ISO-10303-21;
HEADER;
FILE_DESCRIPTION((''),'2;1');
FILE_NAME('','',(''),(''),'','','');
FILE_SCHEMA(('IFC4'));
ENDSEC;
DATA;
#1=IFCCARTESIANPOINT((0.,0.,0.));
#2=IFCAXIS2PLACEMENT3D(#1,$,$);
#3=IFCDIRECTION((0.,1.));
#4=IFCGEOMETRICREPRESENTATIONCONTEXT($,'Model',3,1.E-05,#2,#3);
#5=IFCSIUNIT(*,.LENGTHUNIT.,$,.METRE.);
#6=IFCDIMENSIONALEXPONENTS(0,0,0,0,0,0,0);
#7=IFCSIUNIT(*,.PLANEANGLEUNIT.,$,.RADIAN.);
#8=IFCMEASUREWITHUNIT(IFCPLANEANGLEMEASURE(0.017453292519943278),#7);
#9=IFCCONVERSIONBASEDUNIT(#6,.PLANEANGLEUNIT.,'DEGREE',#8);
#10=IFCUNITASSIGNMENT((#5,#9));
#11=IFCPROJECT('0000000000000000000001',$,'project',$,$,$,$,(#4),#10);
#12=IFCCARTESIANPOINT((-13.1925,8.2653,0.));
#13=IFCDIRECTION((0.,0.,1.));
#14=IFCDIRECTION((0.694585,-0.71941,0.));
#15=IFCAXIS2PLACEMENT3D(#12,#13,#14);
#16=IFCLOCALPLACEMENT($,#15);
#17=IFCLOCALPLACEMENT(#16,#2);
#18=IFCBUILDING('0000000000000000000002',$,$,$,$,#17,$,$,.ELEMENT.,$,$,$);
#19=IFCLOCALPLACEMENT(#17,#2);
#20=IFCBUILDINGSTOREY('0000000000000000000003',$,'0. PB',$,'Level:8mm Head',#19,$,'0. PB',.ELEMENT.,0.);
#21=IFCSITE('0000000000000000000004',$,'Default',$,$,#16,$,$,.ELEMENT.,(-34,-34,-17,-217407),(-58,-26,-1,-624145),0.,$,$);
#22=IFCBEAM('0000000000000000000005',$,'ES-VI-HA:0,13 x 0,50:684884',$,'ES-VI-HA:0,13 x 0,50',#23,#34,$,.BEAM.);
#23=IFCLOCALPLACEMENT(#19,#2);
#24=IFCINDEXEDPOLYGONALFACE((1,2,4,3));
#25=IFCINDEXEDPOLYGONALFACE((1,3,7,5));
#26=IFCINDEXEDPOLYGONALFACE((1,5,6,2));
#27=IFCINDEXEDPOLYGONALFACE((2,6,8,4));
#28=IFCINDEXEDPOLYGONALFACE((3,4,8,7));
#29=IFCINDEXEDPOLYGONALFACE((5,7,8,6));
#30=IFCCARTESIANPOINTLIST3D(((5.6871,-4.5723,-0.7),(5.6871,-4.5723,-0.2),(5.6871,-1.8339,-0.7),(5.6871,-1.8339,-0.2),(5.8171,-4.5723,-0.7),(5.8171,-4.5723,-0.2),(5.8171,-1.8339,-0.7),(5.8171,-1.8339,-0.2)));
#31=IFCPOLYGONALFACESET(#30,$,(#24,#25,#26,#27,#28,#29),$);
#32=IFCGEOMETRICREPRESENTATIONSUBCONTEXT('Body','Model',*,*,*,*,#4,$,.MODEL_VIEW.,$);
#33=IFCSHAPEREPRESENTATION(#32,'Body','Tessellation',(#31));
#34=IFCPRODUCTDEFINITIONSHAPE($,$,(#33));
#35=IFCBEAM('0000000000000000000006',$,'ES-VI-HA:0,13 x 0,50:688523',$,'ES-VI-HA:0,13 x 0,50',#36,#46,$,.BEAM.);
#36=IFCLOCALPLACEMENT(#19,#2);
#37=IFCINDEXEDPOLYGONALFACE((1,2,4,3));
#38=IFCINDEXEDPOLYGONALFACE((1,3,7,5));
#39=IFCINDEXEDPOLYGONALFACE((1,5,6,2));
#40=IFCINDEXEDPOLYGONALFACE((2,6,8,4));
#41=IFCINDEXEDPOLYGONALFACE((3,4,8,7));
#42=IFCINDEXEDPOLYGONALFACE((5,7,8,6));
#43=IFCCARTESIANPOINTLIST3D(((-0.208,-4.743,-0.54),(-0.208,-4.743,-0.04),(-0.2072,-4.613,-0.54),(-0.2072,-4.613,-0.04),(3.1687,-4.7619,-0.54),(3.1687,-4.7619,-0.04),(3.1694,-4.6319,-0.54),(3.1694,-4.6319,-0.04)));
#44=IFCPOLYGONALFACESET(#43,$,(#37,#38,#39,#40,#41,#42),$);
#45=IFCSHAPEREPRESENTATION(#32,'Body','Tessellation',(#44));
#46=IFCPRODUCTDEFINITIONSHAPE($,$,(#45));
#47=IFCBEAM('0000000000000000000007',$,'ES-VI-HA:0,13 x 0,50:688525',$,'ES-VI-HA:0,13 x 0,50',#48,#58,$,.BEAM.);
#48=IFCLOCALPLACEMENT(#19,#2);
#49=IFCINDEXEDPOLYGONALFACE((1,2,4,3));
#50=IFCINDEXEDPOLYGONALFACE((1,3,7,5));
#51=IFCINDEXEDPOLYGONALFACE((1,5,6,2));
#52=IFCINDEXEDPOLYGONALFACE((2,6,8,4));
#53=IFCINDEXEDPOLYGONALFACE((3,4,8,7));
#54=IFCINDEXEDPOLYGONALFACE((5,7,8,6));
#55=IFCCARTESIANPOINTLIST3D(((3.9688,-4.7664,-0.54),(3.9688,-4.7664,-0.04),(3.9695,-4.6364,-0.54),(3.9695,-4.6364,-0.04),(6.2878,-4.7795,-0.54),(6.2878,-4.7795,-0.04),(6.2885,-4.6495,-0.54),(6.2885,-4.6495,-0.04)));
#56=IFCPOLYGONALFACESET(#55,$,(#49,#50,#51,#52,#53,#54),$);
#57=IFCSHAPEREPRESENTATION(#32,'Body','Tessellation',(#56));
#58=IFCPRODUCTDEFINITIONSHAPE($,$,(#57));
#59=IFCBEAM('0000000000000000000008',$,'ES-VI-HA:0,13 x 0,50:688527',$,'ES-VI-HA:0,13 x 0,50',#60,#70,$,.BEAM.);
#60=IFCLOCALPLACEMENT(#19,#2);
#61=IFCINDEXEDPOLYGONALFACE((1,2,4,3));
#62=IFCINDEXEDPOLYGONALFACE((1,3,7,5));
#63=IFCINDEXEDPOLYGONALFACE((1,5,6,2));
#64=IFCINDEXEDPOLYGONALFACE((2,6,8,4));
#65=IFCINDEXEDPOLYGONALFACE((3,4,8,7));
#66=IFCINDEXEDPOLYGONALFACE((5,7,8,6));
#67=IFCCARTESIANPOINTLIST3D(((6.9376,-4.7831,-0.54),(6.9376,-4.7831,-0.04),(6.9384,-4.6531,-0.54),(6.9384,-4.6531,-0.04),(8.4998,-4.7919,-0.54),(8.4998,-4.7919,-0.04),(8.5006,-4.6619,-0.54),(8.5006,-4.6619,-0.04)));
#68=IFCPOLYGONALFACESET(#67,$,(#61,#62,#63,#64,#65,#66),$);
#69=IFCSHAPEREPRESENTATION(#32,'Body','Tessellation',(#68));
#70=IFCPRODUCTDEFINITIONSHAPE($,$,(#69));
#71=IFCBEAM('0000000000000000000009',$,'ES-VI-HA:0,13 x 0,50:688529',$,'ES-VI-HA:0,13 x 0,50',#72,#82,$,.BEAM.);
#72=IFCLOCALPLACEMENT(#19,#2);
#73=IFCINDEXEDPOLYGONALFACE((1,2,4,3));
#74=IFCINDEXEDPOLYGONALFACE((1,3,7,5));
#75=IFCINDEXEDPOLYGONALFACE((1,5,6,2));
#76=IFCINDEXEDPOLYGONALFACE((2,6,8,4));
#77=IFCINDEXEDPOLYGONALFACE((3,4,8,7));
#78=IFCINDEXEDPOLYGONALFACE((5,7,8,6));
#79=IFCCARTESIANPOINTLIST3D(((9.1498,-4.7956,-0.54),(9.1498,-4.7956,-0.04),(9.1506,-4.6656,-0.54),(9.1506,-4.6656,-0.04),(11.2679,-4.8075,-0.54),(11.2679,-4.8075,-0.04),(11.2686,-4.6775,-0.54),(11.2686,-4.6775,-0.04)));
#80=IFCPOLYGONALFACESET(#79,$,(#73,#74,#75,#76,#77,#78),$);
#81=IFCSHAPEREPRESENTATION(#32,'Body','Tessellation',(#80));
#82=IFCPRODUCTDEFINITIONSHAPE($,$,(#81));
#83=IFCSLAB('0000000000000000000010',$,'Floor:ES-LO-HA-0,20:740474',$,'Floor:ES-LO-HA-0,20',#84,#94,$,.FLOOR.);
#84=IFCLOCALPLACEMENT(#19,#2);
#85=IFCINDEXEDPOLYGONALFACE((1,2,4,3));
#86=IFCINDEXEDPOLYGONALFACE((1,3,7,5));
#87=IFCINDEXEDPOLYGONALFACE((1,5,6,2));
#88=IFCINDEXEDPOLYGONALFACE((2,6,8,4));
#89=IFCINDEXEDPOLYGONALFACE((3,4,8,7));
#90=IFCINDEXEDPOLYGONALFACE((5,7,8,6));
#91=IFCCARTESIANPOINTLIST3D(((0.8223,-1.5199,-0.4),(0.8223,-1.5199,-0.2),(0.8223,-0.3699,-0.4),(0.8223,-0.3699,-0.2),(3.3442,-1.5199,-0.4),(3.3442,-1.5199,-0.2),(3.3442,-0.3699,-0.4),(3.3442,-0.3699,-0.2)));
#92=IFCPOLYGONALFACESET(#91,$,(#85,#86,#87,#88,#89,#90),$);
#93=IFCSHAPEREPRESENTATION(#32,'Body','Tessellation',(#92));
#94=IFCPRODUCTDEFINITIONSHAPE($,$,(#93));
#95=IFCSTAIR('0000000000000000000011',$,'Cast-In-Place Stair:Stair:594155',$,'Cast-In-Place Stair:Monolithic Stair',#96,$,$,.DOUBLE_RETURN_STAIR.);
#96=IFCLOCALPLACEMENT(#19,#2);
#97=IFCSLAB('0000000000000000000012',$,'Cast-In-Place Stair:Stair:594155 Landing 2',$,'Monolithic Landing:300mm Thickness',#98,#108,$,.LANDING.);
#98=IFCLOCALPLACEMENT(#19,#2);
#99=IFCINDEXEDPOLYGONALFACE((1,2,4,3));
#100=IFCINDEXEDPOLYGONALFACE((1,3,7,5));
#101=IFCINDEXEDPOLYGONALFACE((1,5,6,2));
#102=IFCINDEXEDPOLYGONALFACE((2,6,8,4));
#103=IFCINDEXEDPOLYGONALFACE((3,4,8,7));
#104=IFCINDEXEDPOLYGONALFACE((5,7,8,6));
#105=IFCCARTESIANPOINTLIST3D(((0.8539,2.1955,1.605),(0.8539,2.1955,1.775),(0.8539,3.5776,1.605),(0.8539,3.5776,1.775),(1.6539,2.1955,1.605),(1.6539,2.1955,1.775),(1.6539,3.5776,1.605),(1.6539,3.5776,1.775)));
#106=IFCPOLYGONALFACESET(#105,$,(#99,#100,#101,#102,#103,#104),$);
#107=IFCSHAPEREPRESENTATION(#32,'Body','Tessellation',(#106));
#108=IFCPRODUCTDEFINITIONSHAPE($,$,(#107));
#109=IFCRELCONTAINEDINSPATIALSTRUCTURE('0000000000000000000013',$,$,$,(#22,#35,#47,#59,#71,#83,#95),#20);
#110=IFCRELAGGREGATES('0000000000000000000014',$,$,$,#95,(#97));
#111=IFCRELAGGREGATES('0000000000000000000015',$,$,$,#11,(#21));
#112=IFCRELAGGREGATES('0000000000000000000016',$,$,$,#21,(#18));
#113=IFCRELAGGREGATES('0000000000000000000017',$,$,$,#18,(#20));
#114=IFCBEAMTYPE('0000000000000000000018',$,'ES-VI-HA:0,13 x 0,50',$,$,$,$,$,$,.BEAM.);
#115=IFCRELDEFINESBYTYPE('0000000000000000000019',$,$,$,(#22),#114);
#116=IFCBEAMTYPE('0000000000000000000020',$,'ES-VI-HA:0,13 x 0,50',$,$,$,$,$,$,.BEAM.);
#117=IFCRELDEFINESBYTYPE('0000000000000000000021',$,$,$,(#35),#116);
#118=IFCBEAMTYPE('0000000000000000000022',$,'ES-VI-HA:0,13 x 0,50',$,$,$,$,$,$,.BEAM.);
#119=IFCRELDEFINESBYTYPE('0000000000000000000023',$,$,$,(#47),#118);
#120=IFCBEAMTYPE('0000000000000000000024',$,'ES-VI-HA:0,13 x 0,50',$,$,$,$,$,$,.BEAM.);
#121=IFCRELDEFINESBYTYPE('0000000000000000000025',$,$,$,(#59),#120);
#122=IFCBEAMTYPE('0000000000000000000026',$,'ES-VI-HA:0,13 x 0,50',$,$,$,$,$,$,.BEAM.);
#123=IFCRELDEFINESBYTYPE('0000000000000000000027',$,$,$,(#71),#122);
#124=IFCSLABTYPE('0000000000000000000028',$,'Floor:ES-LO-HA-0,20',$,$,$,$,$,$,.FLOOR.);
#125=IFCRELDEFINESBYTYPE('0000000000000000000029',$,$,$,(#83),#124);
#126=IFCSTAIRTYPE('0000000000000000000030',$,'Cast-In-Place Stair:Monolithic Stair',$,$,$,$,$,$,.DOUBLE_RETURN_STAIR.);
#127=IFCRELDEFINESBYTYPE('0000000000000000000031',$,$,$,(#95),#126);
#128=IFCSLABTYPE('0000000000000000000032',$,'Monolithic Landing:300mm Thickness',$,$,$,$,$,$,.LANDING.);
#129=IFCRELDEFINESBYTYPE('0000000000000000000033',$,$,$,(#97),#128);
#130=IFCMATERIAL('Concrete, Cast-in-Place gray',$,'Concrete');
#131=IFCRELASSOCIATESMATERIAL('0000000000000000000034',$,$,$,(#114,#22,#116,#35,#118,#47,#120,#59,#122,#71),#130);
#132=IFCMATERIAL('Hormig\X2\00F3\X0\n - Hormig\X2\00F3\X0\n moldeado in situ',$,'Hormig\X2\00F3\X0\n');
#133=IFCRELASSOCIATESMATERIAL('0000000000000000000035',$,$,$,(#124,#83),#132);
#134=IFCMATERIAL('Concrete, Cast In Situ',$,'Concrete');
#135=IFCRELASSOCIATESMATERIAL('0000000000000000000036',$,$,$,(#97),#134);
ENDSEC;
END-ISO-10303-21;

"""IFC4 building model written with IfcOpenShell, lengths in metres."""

from ifc_helpers import new_model, entity, si_unit, converted_unit, direction, frame, origin, place, context, subcontext, project, spatial, indexed_curve, outline, extrude, source, transform, mapped, material, type_object, type_shapes, element, aggregate, save


model = new_model("IFC4")

# Units and contexts
model_context = context("Model", 3, precision=1e-05, world=origin(), true_north=direction((0.0, 1.0)))
body_context = subcontext(model_context, "Body", "Model", "MODEL_VIEW")
ifc_project = project(units=[si_unit("LENGTHUNIT", "METRE"), converted_unit("PLANEANGLEUNIT", "DEGREE", entity("IfcPlaneAngleMeasure", 0.017453292519943278), si_unit("PLANEANGLEUNIT", "RADIAN"), dimensions=[0, 0, 0, 0, 0, 0, 0])], contexts=[model_context])

# Site, building, storey
site_placement = place(None, frame((-13.1925, 8.2653, 0.0), z_axis=(0.0, 0.0, 1.0), x_axis=(0.694585, -0.71941, 0.0)))
site = spatial("IfcSite", under=ifc_project, at=site_placement, Name="Default", CompositionType="ELEMENT", RefLatitude=(-34, -34, -17, -217407), RefLongitude=(-58, -26, -1, -624145), RefElevation=0.0)
building_placement = place(site_placement, origin())
building = spatial("IfcBuilding", under=site, at=building_placement, CompositionType="ELEMENT")
storey_placement = place(building_placement, origin())
storey = spatial("IfcBuildingStorey", under=building, at=storey_placement, Name="0. PB", ObjectType="Level:8mm Head", LongName="0. PB", CompositionType="ELEMENT", Elevation=0.0)

# Shared definitions
ifc_material_1 = material(Name="Concrete, Cast-in-Place gray", Category="Concrete")

# Beams
beam_type_1 = type_object("IfcBeamType", Name="ES-VI-HA:0,13 x 0,50", PredefinedType="BEAM", material=ifc_material_1)
shared_shape_1 = source(origin(), body_context, "Body", "SweptSolid", [
    extrude(outline(indexed_curve([(-0.065, -0.25), (0.065, -0.25), (0.065, 0.25), (-0.065, 0.25), (-0.065, -0.25)], self_intersect=False)), frame((5.7521, -1.8339, -0.45), z_axis=(0.0, -1.0, 0.0), x_axis=(-1.0, 0.0, 0.0)), (0.0, 0.0, 1.0), 2.7384),
])
type_shapes(beam_type_1, [shared_shape_1])
beam_1_placement = place(storey_placement, origin())
element("IfcBeam", 1, at=beam_1_placement, inside=storey, type_object=beam_type_1, material=ifc_material_1, Name="ES-VI-HA:0,13 x 0,50:684884", ObjectType="ES-VI-HA:0,13 x 0,50", PredefinedType="BEAM", context=body_context, shape_type="MappedRepresentation", body=[
    mapped(shared_shape_1, transform((0.0, 0.0, 0.0), scale=1.0)),
])
beam_type_2 = type_object("IfcBeamType", Name="ES-VI-HA:0,13 x 0,50", PredefinedType="BEAM", material=ifc_material_1)
shared_shape_2 = source(origin(), body_context, "Body", "SweptSolid", [
    extrude(outline(indexed_curve([(-0.25, -0.065), (0.25, -0.065), (0.25, 0.065), (-0.25, 0.065), (-0.25, -0.065)], self_intersect=False)), frame((-0.2076, -4.678, -0.29), z_axis=(0.999984, -0.005619, 0.0), x_axis=(0.0, 0.0, -1.0)), (0.0, 0.0, 1.0), 3.3767),
])
type_shapes(beam_type_2, [shared_shape_2])
beam_2_placement = place(storey_placement, origin())
element("IfcBeam", 2, at=beam_2_placement, inside=storey, type_object=beam_type_2, material=ifc_material_1, Name="ES-VI-HA:0,13 x 0,50:688523", ObjectType="ES-VI-HA:0,13 x 0,50", PredefinedType="BEAM", context=body_context, shape_type="MappedRepresentation", body=[
    mapped(shared_shape_2, transform((0.0, 0.0, 0.0), scale=1.0)),
])
beam_type_3 = type_object("IfcBeamType", Name="ES-VI-HA:0,13 x 0,50", PredefinedType="BEAM", material=ifc_material_1)
shared_shape_3 = source(origin(), body_context, "Body", "SweptSolid", [
    extrude(outline(indexed_curve([(-0.25, -0.065), (0.25, -0.065), (0.25, 0.065), (-0.25, 0.065), (-0.25, -0.065)], self_intersect=False)), frame((3.9692, -4.7014, -0.29), z_axis=(0.999984, -0.005619, 0.0), x_axis=(0.0, 0.0, -1.0)), (0.0, 0.0, 1.0), 2.319),
])
type_shapes(beam_type_3, [shared_shape_3])
beam_3_placement = place(storey_placement, origin())
element("IfcBeam", 3, at=beam_3_placement, inside=storey, type_object=beam_type_3, material=ifc_material_1, Name="ES-VI-HA:0,13 x 0,50:688525", ObjectType="ES-VI-HA:0,13 x 0,50", PredefinedType="BEAM", context=body_context, shape_type="MappedRepresentation", body=[
    mapped(shared_shape_3, transform((0.0, 0.0, 0.0), scale=1.0)),
])
beam_type_4 = type_object("IfcBeamType", Name="ES-VI-HA:0,13 x 0,50", PredefinedType="BEAM", material=ifc_material_1)
shared_shape_4 = source(origin(), body_context, "Body", "SweptSolid", [
    extrude(outline(indexed_curve([(-0.25, -0.065), (0.25, -0.065), (0.25, 0.065), (-0.25, 0.065), (-0.25, -0.065)], self_intersect=False)), frame((6.938, -4.7181, -0.29), z_axis=(0.999984, -0.005619, 0.0), x_axis=(0.0, 0.0, -1.0)), (0.0, 0.0, 1.0), 1.5622),
])
type_shapes(beam_type_4, [shared_shape_4])
beam_4_placement = place(storey_placement, origin())
element("IfcBeam", 4, at=beam_4_placement, inside=storey, type_object=beam_type_4, material=ifc_material_1, Name="ES-VI-HA:0,13 x 0,50:688527", ObjectType="ES-VI-HA:0,13 x 0,50", PredefinedType="BEAM", context=body_context, shape_type="MappedRepresentation", body=[
    mapped(shared_shape_4, transform((0.0, 0.0, 0.0), scale=1.0)),
])
beam_type_5 = type_object("IfcBeamType", Name="ES-VI-HA:0,13 x 0,50", PredefinedType="BEAM", material=ifc_material_1)
shared_shape_5 = source(origin(), body_context, "Body", "SweptSolid", [
    extrude(outline(indexed_curve([(-0.25, -0.065), (0.25, -0.065), (0.25, 0.065), (-0.25, 0.065), (-0.25, -0.065)], self_intersect=False)), frame((9.1502, -4.7306, -0.29), z_axis=(0.999984, -0.005619, 0.0), x_axis=(0.0, 0.0, -1.0)), (0.0, 0.0, 1.0), 2.1181),
])
type_shapes(beam_type_5, [shared_shape_5])
beam_5_placement = place(storey_placement, origin())
element("IfcBeam", 5, at=beam_5_placement, inside=storey, type_object=beam_type_5, material=ifc_material_1, Name="ES-VI-HA:0,13 x 0,50:688529", ObjectType="ES-VI-HA:0,13 x 0,50", PredefinedType="BEAM", context=body_context, shape_type="MappedRepresentation", body=[
    mapped(shared_shape_5, transform((0.0, 0.0, 0.0), scale=1.0)),
])

# Shared definitions
ifc_material_2 = material(Name="Hormigón - Hormigón moldeado in situ", Category="Hormigón")
slab_type_1 = type_object("IfcSlabType", Name="Floor:ES-LO-HA-0,20", PredefinedType="FLOOR", material=ifc_material_2)

# Slab
slab_1_placement = place(storey_placement, origin())
element("IfcSlab", 6, at=slab_1_placement, inside=storey, type_object=slab_type_1, material=ifc_material_2, Name="Floor:ES-LO-HA-0,20:740474", ObjectType="Floor:ES-LO-HA-0,20", PredefinedType="FLOOR", context=body_context, shape_type="SweptSolid", body=[
    extrude(outline(indexed_curve([(-0.575, -1.2609), (0.575, -1.2609), (0.575, 1.2609), (-0.575, 1.2609), (-0.575, -1.2609)], self_intersect=False)), frame((2.0832, -0.9449, -0.2), z_axis=(0.0, 0.0, -1.0), x_axis=(0.0, 1.0, 0.0)), (0.0, 0.0, 1.0), 0.2),
])

# Stair, slab
stair_type = type_object("IfcStairType", Name="Cast-In-Place Stair:Monolithic Stair", PredefinedType="DOUBLE_RETURN_STAIR")
stair_placement = place(storey_placement, origin())
stair = element("IfcStair", 7, at=stair_placement, inside=storey, type_object=stair_type, Name="Cast-In-Place Stair:Stair:594155", ObjectType="Cast-In-Place Stair:Monolithic Stair", PredefinedType="DOUBLE_RETURN_STAIR")
ifc_material_3 = material(Name="Concrete, Cast In Situ", Category="Concrete")
slab_type_2 = type_object("IfcSlabType", Name="Monolithic Landing:300mm Thickness", PredefinedType="LANDING")
slab_2_placement = place(stair_placement, origin())
slab_2 = element("IfcSlab", 8, at=slab_2_placement, type_object=slab_type_2, material=ifc_material_3, Name="Cast-In-Place Stair:Stair:594155 Landing 2", ObjectType="Monolithic Landing:300mm Thickness", PredefinedType="LANDING", context=body_context, shape_type="SweptSolid", body=[
    extrude(outline(indexed_curve([(-0.4, -0.6911), (0.4, -0.6911), (0.4, 0.6911), (-0.4, 0.6911), (-0.4, -0.6911)], self_intersect=False)), frame((1.2539, 2.8866, 1.605)), (0.0, 0.0, 1.0), 0.17),
])
aggregate(stair, [slab_2])

save(model, "model.ifc")
